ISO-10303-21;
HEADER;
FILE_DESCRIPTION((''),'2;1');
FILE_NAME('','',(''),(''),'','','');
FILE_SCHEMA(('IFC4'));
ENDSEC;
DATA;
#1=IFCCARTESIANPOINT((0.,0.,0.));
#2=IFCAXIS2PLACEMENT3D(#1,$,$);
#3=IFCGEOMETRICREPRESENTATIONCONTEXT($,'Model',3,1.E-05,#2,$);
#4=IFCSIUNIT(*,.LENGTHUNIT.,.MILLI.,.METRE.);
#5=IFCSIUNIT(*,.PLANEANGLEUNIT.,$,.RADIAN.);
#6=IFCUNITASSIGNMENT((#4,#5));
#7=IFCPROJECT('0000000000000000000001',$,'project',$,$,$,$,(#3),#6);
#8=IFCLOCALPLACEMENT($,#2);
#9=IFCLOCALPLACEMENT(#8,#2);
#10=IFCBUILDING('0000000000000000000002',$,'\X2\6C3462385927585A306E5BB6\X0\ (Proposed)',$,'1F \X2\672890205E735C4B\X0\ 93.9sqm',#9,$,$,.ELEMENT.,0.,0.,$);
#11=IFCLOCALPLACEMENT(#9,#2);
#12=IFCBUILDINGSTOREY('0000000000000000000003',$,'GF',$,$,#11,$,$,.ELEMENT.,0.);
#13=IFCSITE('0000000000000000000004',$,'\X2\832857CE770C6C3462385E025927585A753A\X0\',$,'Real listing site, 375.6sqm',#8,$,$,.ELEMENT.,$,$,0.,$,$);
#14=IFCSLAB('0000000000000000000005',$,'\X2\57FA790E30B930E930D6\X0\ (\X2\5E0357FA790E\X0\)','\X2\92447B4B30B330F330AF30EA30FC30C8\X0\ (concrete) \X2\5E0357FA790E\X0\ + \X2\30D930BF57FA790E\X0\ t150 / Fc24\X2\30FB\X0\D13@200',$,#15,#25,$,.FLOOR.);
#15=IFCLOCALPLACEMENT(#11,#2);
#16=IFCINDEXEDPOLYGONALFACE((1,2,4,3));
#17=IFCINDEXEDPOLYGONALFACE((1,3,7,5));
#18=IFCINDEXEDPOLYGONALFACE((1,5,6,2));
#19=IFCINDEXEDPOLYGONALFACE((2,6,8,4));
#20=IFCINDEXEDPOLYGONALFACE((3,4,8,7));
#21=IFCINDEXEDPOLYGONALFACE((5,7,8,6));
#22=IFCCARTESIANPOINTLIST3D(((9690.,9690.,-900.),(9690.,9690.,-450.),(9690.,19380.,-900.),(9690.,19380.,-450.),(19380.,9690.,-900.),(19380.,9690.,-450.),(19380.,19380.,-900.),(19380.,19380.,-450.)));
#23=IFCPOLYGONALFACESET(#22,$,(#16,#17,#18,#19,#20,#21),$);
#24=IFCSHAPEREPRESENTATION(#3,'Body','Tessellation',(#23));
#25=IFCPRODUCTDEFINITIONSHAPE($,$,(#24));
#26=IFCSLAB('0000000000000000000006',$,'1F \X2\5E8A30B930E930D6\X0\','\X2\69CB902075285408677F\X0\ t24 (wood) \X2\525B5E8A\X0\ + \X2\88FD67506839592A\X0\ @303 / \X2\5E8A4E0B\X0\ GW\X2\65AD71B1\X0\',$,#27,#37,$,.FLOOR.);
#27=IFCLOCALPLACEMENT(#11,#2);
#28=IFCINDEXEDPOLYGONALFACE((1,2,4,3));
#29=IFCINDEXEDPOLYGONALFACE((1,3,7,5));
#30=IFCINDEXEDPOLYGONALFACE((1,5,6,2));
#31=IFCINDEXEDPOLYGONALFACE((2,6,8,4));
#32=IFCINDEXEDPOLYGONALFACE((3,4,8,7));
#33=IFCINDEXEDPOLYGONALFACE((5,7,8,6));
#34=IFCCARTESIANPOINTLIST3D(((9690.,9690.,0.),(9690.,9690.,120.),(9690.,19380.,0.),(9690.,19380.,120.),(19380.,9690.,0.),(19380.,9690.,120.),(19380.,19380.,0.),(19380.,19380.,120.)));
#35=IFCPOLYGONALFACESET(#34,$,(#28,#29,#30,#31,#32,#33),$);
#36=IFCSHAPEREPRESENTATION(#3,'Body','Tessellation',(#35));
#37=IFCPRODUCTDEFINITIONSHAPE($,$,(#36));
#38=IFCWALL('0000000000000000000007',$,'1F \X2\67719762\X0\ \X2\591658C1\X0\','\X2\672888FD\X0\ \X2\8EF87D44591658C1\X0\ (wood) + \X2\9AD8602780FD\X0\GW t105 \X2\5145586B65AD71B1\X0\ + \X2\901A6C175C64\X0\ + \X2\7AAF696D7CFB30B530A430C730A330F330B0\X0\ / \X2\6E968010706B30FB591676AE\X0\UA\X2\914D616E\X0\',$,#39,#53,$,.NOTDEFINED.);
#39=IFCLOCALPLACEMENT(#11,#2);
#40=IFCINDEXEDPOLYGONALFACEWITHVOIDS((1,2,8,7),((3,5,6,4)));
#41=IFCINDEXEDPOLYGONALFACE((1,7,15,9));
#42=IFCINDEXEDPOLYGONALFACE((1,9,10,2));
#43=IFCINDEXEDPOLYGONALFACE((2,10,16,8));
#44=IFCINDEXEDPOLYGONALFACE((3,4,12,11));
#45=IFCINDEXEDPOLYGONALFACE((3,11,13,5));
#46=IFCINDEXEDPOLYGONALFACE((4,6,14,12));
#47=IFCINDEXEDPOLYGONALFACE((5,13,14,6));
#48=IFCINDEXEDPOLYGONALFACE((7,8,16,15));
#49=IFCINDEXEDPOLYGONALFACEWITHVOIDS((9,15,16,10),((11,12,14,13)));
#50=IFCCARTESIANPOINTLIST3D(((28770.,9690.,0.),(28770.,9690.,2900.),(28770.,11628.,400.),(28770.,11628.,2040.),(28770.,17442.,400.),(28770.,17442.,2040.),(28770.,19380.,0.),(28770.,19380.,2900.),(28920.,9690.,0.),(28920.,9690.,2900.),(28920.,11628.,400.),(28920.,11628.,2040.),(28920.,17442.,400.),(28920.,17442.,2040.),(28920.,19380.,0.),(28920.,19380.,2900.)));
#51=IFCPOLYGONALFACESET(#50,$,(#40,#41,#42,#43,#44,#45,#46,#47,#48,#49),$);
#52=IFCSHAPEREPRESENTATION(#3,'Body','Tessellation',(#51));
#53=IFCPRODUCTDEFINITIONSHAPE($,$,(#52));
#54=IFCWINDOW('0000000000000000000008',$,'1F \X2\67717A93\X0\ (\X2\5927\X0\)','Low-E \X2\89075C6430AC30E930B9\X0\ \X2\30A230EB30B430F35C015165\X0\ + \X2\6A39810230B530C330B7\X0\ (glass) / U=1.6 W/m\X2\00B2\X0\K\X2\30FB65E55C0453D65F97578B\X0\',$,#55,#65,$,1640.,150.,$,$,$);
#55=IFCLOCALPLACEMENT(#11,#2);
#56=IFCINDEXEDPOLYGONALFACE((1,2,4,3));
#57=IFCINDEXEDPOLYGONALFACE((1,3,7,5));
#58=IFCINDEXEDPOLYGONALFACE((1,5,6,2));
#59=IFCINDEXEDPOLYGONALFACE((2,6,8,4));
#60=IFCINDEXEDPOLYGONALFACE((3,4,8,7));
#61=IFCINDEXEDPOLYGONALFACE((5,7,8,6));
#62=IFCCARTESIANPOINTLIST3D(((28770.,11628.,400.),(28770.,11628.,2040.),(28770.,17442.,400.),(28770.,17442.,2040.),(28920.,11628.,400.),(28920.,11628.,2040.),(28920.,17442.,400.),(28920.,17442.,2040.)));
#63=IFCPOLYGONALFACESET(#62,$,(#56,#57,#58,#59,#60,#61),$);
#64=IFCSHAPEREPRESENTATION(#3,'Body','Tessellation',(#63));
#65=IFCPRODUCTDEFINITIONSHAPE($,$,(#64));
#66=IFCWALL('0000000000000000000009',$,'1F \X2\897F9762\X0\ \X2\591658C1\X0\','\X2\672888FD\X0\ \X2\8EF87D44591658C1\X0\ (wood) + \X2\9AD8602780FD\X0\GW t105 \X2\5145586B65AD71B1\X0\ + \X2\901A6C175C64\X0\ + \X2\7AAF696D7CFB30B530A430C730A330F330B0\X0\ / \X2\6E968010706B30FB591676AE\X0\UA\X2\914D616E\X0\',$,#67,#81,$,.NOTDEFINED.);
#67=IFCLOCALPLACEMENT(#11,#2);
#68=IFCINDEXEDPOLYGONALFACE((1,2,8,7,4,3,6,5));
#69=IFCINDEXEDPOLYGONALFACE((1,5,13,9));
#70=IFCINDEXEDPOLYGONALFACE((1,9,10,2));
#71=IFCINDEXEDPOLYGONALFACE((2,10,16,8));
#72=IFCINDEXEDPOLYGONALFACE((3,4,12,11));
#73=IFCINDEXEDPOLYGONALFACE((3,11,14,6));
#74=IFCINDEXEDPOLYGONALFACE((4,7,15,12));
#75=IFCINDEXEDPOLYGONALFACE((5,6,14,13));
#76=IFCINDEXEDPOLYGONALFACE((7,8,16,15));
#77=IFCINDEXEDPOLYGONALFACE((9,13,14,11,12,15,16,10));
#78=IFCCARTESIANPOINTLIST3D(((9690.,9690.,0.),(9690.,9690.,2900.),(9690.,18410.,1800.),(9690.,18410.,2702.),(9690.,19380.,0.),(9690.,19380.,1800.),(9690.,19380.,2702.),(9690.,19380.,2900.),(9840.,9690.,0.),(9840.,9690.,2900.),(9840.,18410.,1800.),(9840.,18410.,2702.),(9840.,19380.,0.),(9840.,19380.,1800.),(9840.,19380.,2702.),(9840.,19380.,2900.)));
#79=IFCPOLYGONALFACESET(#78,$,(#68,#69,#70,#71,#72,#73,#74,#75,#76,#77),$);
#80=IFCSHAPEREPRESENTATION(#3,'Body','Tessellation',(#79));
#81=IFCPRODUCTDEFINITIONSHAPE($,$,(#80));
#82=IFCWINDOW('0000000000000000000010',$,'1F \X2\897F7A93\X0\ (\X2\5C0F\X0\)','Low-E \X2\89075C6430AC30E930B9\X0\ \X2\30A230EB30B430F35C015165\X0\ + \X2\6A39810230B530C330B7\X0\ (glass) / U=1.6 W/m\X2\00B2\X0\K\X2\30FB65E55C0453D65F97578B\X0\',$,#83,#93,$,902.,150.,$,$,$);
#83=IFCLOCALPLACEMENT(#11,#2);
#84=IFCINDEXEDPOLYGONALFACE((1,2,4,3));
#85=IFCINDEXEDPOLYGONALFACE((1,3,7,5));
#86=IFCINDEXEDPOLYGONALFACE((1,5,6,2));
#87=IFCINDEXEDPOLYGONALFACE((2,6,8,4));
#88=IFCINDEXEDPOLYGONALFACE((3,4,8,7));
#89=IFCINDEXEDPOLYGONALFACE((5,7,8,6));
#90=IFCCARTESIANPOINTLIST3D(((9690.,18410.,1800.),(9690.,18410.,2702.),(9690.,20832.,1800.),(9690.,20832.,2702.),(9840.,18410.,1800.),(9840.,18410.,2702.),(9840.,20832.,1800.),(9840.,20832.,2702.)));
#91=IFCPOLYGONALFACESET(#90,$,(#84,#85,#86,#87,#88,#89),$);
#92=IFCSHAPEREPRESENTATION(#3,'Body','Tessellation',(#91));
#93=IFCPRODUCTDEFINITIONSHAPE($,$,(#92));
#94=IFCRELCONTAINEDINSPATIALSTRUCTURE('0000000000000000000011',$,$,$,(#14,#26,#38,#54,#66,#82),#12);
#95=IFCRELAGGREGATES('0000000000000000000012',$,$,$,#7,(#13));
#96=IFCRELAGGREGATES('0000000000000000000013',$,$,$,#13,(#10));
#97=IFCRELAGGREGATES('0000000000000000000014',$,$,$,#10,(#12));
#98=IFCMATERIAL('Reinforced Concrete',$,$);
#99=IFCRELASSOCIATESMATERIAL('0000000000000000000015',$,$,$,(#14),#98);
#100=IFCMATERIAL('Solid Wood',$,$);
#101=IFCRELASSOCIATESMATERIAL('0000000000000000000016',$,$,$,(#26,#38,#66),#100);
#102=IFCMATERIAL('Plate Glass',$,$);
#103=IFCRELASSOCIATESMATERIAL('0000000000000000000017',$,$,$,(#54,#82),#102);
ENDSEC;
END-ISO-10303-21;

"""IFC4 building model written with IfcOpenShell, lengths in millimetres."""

from ifc_helpers import new_model, si_unit, frame, frame_2d, origin, place, context, project, spatial, rectangle, extrude, material, element, fill, save


model = new_model("IFC4")

# Units and contexts
model_context = context("Model", 3, precision=1e-05, world=origin())
ifc_project = project(units=[si_unit("LENGTHUNIT", "METRE", prefix="MILLI"), si_unit("PLANEANGLEUNIT", "RADIAN")], contexts=[model_context])

# Site, building, storey
site_placement = place(None, origin())
site = spatial("IfcSite", under=ifc_project, at=site_placement, Name="茨城県水戸市大塚町", ObjectType="Real listing site, 375.6sqm", CompositionType="ELEMENT", RefElevation=0.0)
building_placement = place(site_placement, origin())
building = spatial("IfcBuilding", under=site, at=building_placement, Name="水戸大塚の家 (Proposed)", ObjectType="1F 木造平屋 93.9sqm", CompositionType="ELEMENT", ElevationOfRefHeight=0.0, ElevationOfTerrain=0.0)
storey_placement = place(building_placement, origin())
storey = spatial("IfcBuildingStorey", under=building, at=storey_placement, Name="GF", CompositionType="ELEMENT", Elevation=0.0)

# Slabs
ifc_material_1 = material(Name="Reinforced Concrete")
slab_1_placement = place(storey_placement, frame((4845.0, 4845.0, -450.0)))
element("IfcSlab", 1, at=slab_1_placement, inside=storey, material=ifc_material_1, Name="基礎スラブ (布基礎)", Description="鉄筋コンクリート (concrete) 布基礎 + ベタ基礎 t150 / Fc24・D13@200", PredefinedType="FLOOR", context=model_context, shape_type="SweptSolid", body=[
    extrude(rectangle(XDim=9690.0, YDim=9690.0, at=frame_2d((4845.0, 4845.0))), frame((4845.0, 4845.0, -450.0)), (0.0, 0.0, 1.0), 450.0),
])
ifc_material_2 = material(Name="Solid Wood")
slab_2_placement = place(storey_placement, frame((4845.0, 4845.0, 0.0)))
element("IfcSlab", 2, at=slab_2_placement, inside=storey, material=ifc_material_2, Name="1F 床スラブ", Description="構造用合板 t24 (wood) 剛床 + 製材根太 @303 / 床下 GW断熱", PredefinedType="FLOOR", context=model_context, shape_type="SweptSolid", body=[
    extrude(rectangle(XDim=9690.0, YDim=9690.0, at=frame_2d((4845.0, 4845.0))), frame((4845.0, 4845.0, 0.0)), (0.0, 0.0, 1.0), 120.0),
])

# Shared definitions
ifc_material_3 = material(Name="Plate Glass")

# Walls, openings, windows
wall_1_placement = place(storey_placement, frame((14385.0, 4845.0, 0.0)))
wall_1 = element("IfcWall", 3, at=wall_1_placement, inside=storey, material=ifc_material_2, Name="1F 東面 外壁", Description="木製 軸組外壁 (wood) + 高性能GW t105 充填断熱 + 通気層 + 窯業系サイディング / 準耐火・外皮UA配慮", PredefinedType="NOTDEFINED", context=model_context, shape_type="SweptSolid", body=[
    extrude(rectangle(XDim=150.0, YDim=9690.0, at=frame_2d((75.0, 4845.0))), frame((14385.0, 4845.0, 0.0)), (0.0, 0.0, 1.0), 2900.0),
])
opening_1_placement = place(storey_placement, frame((14385.0, 5814.0, 200.0)))
opening_1 = element("IfcOpeningElement", 4, at=opening_1_placement, cuts=wall_1, PredefinedType="NOTDEFINED", context=model_context, shape_type="SweptSolid", body=[
    extrude(rectangle(XDim=150.0, YDim=5814.0, at=frame_2d((75.0, 2907.0))), frame((14385.0, 5814.0, 200.0)), (0.0, 0.0, 1.0), 1640.0),
])
window_1_placement = place(storey_placement, frame((14385.0, 5814.0, 200.0)))
window_1 = element("IfcWindow", 5, at=window_1_placement, inside=storey, material=ifc_material_3, Name="1F 東窓 (大)", Description="Low-E 複層ガラス アルゴン封入 + 樹脂サッシ (glass) / U=1.6 W/m²K・日射取得型", OverallHeight=1640.0, OverallWidth=150.0, context=model_context, shape_type="SweptSolid", body=[
    extrude(rectangle(XDim=150.0, YDim=5814.0, at=frame_2d((75.0, 2907.0))), frame((14385.0, 5814.0, 200.0)), (0.0, 0.0, 1.0), 1640.0),
])
fill(opening_1, window_1)
wall_2_placement = place(storey_placement, frame((4845.0, 4845.0, 0.0)))
wall_2 = element("IfcWall", 6, at=wall_2_placement, inside=storey, material=ifc_material_2, Name="1F 西面 外壁", Description="木製 軸組外壁 (wood) + 高性能GW t105 充填断熱 + 通気層 + 窯業系サイディング / 準耐火・外皮UA配慮", PredefinedType="NOTDEFINED", context=model_context, shape_type="SweptSolid", body=[
    extrude(rectangle(XDim=150.0, YDim=9690.0, at=frame_2d((75.0, 4845.0))), frame((4845.0, 4845.0, 0.0)), (0.0, 0.0, 1.0), 2900.0),
])
opening_2_placement = place(storey_placement, frame((4845.0, 9205.0, 900.0)))
opening_2 = element("IfcOpeningElement", 7, at=opening_2_placement, cuts=wall_2, PredefinedType="NOTDEFINED", context=model_context, shape_type="SweptSolid", body=[
    extrude(rectangle(XDim=150.0, YDim=2422.0, at=frame_2d((75.0, 1211.0))), frame((4845.0, 9205.0, 900.0)), (0.0, 0.0, 1.0), 902.0),
])
window_2_placement = place(storey_placement, frame((4845.0, 9205.0, 900.0)))
window_2 = element("IfcWindow", 8, at=window_2_placement, inside=storey, material=ifc_material_3, Name="1F 西窓 (小)", Description="Low-E 複層ガラス アルゴン封入 + 樹脂サッシ (glass) / U=1.6 W/m²K・日射取得型", OverallHeight=902.0, OverallWidth=150.0, context=model_context, shape_type="SweptSolid", body=[
    extrude(rectangle(XDim=150.0, YDim=2422.0, at=frame_2d((75.0, 1211.0))), frame((4845.0, 9205.0, 900.0)), (0.0, 0.0, 1.0), 902.0),
])
fill(opening_2, window_2)

save(model, "model.ifc")
